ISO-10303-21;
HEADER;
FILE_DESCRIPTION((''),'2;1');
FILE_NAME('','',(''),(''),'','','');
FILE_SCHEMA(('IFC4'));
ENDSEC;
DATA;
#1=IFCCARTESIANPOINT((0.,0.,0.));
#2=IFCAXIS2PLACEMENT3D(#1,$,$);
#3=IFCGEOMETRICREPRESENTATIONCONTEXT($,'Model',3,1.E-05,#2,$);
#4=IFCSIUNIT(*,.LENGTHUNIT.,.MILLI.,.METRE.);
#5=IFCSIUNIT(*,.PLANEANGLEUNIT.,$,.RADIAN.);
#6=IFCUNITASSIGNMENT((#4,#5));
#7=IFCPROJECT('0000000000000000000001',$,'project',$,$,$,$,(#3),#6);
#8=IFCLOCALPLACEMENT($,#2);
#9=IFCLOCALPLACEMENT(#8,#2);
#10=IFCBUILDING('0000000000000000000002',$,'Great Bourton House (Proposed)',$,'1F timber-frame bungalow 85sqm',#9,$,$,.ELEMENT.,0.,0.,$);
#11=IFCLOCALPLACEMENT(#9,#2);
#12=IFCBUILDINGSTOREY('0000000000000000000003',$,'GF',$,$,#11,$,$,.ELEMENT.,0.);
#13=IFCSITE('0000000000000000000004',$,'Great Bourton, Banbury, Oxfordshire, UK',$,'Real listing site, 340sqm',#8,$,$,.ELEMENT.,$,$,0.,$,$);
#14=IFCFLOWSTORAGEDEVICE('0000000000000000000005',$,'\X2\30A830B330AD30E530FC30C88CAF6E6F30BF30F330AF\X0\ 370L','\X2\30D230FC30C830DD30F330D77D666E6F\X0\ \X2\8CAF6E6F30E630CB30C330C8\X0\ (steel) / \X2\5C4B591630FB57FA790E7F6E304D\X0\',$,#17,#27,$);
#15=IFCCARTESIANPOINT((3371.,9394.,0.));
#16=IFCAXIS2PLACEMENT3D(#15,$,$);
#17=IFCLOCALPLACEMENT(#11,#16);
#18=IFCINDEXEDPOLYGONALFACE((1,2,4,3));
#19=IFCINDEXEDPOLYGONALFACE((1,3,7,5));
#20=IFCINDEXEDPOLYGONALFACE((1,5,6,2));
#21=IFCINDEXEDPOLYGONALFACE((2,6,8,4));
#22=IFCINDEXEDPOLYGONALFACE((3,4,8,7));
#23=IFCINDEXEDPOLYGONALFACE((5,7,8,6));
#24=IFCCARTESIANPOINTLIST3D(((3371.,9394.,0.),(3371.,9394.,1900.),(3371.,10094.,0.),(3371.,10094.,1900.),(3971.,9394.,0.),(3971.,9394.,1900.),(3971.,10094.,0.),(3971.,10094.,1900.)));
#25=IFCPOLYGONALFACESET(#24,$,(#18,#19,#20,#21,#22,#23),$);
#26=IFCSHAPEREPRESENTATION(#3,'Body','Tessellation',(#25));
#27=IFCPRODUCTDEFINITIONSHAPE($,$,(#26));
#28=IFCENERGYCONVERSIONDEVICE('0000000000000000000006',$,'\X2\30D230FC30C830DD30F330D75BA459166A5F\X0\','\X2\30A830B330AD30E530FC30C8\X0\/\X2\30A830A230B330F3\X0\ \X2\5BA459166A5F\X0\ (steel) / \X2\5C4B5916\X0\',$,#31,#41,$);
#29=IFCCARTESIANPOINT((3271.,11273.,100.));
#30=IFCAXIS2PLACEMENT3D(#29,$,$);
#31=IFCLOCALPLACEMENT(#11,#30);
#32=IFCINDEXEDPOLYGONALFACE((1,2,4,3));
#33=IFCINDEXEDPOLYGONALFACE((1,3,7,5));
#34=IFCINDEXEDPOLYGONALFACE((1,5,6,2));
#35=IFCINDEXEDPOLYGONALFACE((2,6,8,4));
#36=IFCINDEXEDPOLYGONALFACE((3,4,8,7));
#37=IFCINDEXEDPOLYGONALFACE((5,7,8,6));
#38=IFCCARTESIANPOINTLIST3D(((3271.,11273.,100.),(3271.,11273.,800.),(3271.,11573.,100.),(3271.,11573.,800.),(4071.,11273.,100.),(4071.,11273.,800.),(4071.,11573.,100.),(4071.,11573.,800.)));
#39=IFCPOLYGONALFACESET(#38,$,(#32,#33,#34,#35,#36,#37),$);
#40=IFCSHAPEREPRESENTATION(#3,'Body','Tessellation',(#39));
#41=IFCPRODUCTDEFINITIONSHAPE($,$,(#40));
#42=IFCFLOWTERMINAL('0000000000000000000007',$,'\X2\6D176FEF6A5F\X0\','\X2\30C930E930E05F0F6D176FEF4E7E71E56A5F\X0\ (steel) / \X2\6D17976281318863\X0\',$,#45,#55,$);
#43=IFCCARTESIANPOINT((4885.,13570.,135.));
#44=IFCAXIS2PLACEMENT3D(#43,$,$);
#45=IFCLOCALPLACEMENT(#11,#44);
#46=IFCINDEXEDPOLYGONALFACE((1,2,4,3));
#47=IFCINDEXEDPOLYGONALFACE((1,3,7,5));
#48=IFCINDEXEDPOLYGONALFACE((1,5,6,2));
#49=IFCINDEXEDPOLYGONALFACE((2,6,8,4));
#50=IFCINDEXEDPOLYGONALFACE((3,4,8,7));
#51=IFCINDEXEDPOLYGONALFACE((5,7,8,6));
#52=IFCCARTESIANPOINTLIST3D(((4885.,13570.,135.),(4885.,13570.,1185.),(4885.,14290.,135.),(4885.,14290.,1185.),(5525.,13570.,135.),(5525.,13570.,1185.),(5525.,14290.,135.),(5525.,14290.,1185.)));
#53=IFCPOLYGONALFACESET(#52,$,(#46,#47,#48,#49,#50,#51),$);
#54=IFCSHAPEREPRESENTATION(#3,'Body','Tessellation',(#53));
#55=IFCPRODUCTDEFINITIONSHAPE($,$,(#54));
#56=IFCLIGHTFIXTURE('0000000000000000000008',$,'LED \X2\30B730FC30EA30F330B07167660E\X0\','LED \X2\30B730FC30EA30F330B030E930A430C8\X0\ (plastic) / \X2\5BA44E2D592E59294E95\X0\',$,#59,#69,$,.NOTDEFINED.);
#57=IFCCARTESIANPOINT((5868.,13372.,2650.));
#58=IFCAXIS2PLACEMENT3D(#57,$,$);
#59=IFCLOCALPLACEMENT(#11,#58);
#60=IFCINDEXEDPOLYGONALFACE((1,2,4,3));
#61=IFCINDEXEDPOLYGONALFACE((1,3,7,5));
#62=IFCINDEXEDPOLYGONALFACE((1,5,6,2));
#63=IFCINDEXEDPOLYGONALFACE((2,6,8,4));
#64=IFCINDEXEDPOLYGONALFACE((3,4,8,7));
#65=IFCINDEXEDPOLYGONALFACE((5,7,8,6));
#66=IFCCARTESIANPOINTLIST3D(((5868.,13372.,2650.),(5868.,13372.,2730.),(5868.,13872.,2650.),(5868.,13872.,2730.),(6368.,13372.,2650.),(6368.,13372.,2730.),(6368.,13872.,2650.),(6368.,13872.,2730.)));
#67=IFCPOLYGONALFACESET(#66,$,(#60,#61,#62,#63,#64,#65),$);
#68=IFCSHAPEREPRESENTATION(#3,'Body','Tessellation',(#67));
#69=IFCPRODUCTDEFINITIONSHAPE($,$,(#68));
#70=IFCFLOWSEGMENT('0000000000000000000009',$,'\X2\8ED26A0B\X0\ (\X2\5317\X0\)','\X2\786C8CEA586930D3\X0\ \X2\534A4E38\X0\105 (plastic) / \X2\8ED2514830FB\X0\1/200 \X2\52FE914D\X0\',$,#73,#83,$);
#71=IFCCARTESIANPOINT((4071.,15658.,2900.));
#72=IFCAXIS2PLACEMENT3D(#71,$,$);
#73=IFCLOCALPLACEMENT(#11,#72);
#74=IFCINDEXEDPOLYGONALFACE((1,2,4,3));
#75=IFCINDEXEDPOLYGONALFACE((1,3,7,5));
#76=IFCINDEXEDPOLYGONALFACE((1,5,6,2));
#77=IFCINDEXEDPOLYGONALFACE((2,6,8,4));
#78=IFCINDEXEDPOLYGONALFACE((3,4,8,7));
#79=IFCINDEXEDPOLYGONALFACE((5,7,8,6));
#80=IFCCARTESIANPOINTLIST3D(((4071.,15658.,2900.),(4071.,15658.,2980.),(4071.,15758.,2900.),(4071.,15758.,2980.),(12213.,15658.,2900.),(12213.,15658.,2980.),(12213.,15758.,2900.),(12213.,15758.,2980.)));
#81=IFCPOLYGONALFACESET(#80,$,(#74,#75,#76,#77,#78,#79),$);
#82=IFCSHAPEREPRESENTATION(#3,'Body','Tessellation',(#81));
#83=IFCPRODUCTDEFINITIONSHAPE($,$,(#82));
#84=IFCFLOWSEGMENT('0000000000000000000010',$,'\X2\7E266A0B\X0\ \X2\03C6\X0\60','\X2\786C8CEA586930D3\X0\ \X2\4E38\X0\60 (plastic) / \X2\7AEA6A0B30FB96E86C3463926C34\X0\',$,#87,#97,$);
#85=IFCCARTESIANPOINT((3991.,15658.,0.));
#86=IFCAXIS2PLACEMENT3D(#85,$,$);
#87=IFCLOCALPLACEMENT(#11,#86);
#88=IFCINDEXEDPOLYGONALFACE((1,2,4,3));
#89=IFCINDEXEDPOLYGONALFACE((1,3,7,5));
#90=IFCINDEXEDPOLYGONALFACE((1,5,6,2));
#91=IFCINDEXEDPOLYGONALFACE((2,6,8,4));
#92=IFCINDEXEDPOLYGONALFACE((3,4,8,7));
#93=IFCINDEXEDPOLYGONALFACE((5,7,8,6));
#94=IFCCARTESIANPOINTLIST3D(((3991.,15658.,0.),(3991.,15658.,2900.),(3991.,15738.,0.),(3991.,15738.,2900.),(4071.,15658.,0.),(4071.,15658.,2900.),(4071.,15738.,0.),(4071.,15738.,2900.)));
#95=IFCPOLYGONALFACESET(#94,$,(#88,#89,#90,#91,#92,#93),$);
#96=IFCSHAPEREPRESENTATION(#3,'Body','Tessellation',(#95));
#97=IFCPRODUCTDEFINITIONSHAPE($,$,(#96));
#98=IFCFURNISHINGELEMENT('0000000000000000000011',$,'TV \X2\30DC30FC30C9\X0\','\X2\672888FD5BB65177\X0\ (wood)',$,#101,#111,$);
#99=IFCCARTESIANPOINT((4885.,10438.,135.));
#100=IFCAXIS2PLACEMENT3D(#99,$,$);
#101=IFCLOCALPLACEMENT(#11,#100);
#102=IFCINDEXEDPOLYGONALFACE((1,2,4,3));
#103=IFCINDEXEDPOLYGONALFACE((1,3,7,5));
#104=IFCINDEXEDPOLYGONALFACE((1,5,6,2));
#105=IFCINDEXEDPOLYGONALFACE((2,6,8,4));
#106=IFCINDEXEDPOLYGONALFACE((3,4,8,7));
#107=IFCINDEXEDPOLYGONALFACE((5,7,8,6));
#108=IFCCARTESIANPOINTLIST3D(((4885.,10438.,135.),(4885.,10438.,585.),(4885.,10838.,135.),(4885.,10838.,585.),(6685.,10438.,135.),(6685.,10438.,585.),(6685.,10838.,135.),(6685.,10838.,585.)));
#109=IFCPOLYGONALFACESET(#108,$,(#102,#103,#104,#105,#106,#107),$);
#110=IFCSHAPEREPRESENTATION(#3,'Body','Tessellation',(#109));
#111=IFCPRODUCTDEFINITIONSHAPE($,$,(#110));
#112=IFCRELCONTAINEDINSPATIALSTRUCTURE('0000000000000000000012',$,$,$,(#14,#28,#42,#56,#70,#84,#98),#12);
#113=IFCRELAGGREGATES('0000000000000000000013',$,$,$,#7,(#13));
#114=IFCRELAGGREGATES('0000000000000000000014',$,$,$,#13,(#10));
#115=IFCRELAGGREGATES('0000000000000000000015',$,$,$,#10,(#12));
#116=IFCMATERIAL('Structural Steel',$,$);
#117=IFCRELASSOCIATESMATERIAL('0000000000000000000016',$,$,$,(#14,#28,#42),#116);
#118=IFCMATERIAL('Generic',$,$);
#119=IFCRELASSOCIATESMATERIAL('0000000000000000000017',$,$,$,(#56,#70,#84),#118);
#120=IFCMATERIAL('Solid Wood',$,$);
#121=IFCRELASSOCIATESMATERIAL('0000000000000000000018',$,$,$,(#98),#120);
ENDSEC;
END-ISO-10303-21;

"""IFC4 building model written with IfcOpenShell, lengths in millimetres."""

from ifc_helpers import new_model, si_unit, frame, frame_2d, origin, place, context, project, spatial, rectangle, extrude, material, element, save


model = new_model("IFC4")

# Units and contexts
model_context = context("Model", 3, precision=1e-05, world=origin())
ifc_project = project(units=[si_unit("LENGTHUNIT", "METRE", prefix="MILLI"), si_unit("PLANEANGLEUNIT", "RADIAN")], contexts=[model_context])

# Site, building, storey
site_placement = place(None, origin())
site = spatial("IfcSite", under=ifc_project, at=site_placement, Name="Great Bourton, Banbury, Oxfordshire, UK", ObjectType="Real listing site, 340sqm", CompositionType="ELEMENT", RefElevation=0.0)
building_placement = place(site_placement, origin())
building = spatial("IfcBuilding", under=site, at=building_placement, Name="Great Bourton House (Proposed)", ObjectType="1F timber-frame bungalow 85sqm", CompositionType="ELEMENT", ElevationOfRefHeight=0.0, ElevationOfTerrain=0.0)
storey_placement = place(building_placement, origin())
storey = spatial("IfcBuildingStorey", under=building, at=storey_placement, Name="GF", CompositionType="ELEMENT", Elevation=0.0)

# Shared definitions
ifc_material_1 = material(Name="Solid Wood")

# Shared definitions
ifc_material_2 = material(Name="Structural Steel")

# Shared definitions
ifc_material_3 = material(Name="Generic")

# Flow storage device
flow_storage_device_placement = place(storey_placement, frame((3371.0, 9394.0, 0.0)))
element("IfcFlowStorageDevice", 1, at=flow_storage_device_placement, inside=storey, material=ifc_material_2, Name="エコキュート貯湯タンク 370L", Description="ヒートポンプ給湯 貯湯ユニット (steel) / 屋外・基礎置き", context=model_context, shape_type="SweptSolid", body=[
    extrude(rectangle(XDim=600.0, YDim=700.0, at=frame_2d((300.0, 350.0))), frame((3371.0, 9394.0, 0.0)), (0.0, 0.0, 1.0), 1900.0),
])

# Energy conversion device
energy_conversion_device_placement = place(storey_placement, frame((3271.0, 11273.0, 100.0)))
element("IfcEnergyConversionDevice", 2, at=energy_conversion_device_placement, inside=storey, material=ifc_material_2, Name="ヒートポンプ室外機", Description="エコキュート/エアコン 室外機 (steel) / 屋外", context=model_context, shape_type="SweptSolid", body=[
    extrude(rectangle(XDim=800.0, YDim=300.0, at=frame_2d((400.0, 150.0))), frame((3271.0, 11273.0, 100.0)), (0.0, 0.0, 1.0), 700.0),
])

# Flow terminal
flow_terminal_placement = place(storey_placement, frame((4885.0, 13570.0, 135.0)))
element("IfcFlowTerminal", 3, at=flow_terminal_placement, inside=storey, material=ifc_material_2, Name="洗濯機", Description="ドラム式洗濯乾燥機 (steel) / 洗面脱衣", context=model_context, shape_type="SweptSolid", body=[
    extrude(rectangle(XDim=640.0, YDim=720.0, at=frame_2d((320.0, 360.0))), frame((4885.0, 13570.0, 135.0)), (0.0, 0.0, 1.0), 1050.0),
])

# Light fixture
light_fixture_placement = place(storey_placement, frame((5868.0, 13372.0, 2650.0)))
element("IfcLightFixture", 4, at=light_fixture_placement, inside=storey, material=ifc_material_3, Name="LED シーリング照明", Description="LED シーリングライト (plastic) / 室中央天井", PredefinedType="NOTDEFINED", context=model_context, shape_type="SweptSolid", body=[
    extrude(rectangle(XDim=500.0, YDim=500.0, at=frame_2d((250.0, 250.0))), frame((5868.0, 13372.0, 2650.0)), (0.0, 0.0, 1.0), 80.0),
])

# Flow segments
flow_segment_1_placement = place(storey_placement, frame((4071.0, 15658.0, 2900.0)))
element("IfcFlowSegment", 5, at=flow_segment_1_placement, inside=storey, material=ifc_material_3, Name="軒樋 (北)", Description="硬質塩ビ 半丸105 (plastic) / 軒先・1/200 勾配", context=model_context, shape_type="SweptSolid", body=[
    extrude(rectangle(XDim=8142.0, YDim=100.0, at=frame_2d((4071.0, 50.0))), frame((4071.0, 15658.0, 2900.0)), (0.0, 0.0, 1.0), 80.0),
])
flow_segment_2_placement = place(storey_placement, frame((3991.0, 15658.0, 0.0)))
element("IfcFlowSegment", 6, at=flow_segment_2_placement, inside=storey, material=ifc_material_3, Name="縦樋 φ60", Description="硬質塩ビ 丸60 (plastic) / 竪樋・雨水排水", context=model_context, shape_type="SweptSolid", body=[
    extrude(rectangle(XDim=80.0, YDim=80.0, at=frame_2d((40.0, 40.0))), frame((3991.0, 15658.0, 0.0)), (0.0, 0.0, 1.0), 2900.0),
])

# Furnishing element
furnishing_placement = place(storey_placement, frame((4885.0, 10438.0, 135.0)))
element("IfcFurnishingElement", 7, at=furnishing_placement, inside=storey, material=ifc_material_1, Name="TV ボード", Description="木製家具 (wood)", context=model_context, shape_type="SweptSolid", body=[
    extrude(rectangle(XDim=1800.0, YDim=400.0, at=frame_2d((900.0, 200.0))), frame((4885.0, 10438.0, 135.0)), (0.0, 0.0, 1.0), 450.0),
])

save(model, "model.ifc")
